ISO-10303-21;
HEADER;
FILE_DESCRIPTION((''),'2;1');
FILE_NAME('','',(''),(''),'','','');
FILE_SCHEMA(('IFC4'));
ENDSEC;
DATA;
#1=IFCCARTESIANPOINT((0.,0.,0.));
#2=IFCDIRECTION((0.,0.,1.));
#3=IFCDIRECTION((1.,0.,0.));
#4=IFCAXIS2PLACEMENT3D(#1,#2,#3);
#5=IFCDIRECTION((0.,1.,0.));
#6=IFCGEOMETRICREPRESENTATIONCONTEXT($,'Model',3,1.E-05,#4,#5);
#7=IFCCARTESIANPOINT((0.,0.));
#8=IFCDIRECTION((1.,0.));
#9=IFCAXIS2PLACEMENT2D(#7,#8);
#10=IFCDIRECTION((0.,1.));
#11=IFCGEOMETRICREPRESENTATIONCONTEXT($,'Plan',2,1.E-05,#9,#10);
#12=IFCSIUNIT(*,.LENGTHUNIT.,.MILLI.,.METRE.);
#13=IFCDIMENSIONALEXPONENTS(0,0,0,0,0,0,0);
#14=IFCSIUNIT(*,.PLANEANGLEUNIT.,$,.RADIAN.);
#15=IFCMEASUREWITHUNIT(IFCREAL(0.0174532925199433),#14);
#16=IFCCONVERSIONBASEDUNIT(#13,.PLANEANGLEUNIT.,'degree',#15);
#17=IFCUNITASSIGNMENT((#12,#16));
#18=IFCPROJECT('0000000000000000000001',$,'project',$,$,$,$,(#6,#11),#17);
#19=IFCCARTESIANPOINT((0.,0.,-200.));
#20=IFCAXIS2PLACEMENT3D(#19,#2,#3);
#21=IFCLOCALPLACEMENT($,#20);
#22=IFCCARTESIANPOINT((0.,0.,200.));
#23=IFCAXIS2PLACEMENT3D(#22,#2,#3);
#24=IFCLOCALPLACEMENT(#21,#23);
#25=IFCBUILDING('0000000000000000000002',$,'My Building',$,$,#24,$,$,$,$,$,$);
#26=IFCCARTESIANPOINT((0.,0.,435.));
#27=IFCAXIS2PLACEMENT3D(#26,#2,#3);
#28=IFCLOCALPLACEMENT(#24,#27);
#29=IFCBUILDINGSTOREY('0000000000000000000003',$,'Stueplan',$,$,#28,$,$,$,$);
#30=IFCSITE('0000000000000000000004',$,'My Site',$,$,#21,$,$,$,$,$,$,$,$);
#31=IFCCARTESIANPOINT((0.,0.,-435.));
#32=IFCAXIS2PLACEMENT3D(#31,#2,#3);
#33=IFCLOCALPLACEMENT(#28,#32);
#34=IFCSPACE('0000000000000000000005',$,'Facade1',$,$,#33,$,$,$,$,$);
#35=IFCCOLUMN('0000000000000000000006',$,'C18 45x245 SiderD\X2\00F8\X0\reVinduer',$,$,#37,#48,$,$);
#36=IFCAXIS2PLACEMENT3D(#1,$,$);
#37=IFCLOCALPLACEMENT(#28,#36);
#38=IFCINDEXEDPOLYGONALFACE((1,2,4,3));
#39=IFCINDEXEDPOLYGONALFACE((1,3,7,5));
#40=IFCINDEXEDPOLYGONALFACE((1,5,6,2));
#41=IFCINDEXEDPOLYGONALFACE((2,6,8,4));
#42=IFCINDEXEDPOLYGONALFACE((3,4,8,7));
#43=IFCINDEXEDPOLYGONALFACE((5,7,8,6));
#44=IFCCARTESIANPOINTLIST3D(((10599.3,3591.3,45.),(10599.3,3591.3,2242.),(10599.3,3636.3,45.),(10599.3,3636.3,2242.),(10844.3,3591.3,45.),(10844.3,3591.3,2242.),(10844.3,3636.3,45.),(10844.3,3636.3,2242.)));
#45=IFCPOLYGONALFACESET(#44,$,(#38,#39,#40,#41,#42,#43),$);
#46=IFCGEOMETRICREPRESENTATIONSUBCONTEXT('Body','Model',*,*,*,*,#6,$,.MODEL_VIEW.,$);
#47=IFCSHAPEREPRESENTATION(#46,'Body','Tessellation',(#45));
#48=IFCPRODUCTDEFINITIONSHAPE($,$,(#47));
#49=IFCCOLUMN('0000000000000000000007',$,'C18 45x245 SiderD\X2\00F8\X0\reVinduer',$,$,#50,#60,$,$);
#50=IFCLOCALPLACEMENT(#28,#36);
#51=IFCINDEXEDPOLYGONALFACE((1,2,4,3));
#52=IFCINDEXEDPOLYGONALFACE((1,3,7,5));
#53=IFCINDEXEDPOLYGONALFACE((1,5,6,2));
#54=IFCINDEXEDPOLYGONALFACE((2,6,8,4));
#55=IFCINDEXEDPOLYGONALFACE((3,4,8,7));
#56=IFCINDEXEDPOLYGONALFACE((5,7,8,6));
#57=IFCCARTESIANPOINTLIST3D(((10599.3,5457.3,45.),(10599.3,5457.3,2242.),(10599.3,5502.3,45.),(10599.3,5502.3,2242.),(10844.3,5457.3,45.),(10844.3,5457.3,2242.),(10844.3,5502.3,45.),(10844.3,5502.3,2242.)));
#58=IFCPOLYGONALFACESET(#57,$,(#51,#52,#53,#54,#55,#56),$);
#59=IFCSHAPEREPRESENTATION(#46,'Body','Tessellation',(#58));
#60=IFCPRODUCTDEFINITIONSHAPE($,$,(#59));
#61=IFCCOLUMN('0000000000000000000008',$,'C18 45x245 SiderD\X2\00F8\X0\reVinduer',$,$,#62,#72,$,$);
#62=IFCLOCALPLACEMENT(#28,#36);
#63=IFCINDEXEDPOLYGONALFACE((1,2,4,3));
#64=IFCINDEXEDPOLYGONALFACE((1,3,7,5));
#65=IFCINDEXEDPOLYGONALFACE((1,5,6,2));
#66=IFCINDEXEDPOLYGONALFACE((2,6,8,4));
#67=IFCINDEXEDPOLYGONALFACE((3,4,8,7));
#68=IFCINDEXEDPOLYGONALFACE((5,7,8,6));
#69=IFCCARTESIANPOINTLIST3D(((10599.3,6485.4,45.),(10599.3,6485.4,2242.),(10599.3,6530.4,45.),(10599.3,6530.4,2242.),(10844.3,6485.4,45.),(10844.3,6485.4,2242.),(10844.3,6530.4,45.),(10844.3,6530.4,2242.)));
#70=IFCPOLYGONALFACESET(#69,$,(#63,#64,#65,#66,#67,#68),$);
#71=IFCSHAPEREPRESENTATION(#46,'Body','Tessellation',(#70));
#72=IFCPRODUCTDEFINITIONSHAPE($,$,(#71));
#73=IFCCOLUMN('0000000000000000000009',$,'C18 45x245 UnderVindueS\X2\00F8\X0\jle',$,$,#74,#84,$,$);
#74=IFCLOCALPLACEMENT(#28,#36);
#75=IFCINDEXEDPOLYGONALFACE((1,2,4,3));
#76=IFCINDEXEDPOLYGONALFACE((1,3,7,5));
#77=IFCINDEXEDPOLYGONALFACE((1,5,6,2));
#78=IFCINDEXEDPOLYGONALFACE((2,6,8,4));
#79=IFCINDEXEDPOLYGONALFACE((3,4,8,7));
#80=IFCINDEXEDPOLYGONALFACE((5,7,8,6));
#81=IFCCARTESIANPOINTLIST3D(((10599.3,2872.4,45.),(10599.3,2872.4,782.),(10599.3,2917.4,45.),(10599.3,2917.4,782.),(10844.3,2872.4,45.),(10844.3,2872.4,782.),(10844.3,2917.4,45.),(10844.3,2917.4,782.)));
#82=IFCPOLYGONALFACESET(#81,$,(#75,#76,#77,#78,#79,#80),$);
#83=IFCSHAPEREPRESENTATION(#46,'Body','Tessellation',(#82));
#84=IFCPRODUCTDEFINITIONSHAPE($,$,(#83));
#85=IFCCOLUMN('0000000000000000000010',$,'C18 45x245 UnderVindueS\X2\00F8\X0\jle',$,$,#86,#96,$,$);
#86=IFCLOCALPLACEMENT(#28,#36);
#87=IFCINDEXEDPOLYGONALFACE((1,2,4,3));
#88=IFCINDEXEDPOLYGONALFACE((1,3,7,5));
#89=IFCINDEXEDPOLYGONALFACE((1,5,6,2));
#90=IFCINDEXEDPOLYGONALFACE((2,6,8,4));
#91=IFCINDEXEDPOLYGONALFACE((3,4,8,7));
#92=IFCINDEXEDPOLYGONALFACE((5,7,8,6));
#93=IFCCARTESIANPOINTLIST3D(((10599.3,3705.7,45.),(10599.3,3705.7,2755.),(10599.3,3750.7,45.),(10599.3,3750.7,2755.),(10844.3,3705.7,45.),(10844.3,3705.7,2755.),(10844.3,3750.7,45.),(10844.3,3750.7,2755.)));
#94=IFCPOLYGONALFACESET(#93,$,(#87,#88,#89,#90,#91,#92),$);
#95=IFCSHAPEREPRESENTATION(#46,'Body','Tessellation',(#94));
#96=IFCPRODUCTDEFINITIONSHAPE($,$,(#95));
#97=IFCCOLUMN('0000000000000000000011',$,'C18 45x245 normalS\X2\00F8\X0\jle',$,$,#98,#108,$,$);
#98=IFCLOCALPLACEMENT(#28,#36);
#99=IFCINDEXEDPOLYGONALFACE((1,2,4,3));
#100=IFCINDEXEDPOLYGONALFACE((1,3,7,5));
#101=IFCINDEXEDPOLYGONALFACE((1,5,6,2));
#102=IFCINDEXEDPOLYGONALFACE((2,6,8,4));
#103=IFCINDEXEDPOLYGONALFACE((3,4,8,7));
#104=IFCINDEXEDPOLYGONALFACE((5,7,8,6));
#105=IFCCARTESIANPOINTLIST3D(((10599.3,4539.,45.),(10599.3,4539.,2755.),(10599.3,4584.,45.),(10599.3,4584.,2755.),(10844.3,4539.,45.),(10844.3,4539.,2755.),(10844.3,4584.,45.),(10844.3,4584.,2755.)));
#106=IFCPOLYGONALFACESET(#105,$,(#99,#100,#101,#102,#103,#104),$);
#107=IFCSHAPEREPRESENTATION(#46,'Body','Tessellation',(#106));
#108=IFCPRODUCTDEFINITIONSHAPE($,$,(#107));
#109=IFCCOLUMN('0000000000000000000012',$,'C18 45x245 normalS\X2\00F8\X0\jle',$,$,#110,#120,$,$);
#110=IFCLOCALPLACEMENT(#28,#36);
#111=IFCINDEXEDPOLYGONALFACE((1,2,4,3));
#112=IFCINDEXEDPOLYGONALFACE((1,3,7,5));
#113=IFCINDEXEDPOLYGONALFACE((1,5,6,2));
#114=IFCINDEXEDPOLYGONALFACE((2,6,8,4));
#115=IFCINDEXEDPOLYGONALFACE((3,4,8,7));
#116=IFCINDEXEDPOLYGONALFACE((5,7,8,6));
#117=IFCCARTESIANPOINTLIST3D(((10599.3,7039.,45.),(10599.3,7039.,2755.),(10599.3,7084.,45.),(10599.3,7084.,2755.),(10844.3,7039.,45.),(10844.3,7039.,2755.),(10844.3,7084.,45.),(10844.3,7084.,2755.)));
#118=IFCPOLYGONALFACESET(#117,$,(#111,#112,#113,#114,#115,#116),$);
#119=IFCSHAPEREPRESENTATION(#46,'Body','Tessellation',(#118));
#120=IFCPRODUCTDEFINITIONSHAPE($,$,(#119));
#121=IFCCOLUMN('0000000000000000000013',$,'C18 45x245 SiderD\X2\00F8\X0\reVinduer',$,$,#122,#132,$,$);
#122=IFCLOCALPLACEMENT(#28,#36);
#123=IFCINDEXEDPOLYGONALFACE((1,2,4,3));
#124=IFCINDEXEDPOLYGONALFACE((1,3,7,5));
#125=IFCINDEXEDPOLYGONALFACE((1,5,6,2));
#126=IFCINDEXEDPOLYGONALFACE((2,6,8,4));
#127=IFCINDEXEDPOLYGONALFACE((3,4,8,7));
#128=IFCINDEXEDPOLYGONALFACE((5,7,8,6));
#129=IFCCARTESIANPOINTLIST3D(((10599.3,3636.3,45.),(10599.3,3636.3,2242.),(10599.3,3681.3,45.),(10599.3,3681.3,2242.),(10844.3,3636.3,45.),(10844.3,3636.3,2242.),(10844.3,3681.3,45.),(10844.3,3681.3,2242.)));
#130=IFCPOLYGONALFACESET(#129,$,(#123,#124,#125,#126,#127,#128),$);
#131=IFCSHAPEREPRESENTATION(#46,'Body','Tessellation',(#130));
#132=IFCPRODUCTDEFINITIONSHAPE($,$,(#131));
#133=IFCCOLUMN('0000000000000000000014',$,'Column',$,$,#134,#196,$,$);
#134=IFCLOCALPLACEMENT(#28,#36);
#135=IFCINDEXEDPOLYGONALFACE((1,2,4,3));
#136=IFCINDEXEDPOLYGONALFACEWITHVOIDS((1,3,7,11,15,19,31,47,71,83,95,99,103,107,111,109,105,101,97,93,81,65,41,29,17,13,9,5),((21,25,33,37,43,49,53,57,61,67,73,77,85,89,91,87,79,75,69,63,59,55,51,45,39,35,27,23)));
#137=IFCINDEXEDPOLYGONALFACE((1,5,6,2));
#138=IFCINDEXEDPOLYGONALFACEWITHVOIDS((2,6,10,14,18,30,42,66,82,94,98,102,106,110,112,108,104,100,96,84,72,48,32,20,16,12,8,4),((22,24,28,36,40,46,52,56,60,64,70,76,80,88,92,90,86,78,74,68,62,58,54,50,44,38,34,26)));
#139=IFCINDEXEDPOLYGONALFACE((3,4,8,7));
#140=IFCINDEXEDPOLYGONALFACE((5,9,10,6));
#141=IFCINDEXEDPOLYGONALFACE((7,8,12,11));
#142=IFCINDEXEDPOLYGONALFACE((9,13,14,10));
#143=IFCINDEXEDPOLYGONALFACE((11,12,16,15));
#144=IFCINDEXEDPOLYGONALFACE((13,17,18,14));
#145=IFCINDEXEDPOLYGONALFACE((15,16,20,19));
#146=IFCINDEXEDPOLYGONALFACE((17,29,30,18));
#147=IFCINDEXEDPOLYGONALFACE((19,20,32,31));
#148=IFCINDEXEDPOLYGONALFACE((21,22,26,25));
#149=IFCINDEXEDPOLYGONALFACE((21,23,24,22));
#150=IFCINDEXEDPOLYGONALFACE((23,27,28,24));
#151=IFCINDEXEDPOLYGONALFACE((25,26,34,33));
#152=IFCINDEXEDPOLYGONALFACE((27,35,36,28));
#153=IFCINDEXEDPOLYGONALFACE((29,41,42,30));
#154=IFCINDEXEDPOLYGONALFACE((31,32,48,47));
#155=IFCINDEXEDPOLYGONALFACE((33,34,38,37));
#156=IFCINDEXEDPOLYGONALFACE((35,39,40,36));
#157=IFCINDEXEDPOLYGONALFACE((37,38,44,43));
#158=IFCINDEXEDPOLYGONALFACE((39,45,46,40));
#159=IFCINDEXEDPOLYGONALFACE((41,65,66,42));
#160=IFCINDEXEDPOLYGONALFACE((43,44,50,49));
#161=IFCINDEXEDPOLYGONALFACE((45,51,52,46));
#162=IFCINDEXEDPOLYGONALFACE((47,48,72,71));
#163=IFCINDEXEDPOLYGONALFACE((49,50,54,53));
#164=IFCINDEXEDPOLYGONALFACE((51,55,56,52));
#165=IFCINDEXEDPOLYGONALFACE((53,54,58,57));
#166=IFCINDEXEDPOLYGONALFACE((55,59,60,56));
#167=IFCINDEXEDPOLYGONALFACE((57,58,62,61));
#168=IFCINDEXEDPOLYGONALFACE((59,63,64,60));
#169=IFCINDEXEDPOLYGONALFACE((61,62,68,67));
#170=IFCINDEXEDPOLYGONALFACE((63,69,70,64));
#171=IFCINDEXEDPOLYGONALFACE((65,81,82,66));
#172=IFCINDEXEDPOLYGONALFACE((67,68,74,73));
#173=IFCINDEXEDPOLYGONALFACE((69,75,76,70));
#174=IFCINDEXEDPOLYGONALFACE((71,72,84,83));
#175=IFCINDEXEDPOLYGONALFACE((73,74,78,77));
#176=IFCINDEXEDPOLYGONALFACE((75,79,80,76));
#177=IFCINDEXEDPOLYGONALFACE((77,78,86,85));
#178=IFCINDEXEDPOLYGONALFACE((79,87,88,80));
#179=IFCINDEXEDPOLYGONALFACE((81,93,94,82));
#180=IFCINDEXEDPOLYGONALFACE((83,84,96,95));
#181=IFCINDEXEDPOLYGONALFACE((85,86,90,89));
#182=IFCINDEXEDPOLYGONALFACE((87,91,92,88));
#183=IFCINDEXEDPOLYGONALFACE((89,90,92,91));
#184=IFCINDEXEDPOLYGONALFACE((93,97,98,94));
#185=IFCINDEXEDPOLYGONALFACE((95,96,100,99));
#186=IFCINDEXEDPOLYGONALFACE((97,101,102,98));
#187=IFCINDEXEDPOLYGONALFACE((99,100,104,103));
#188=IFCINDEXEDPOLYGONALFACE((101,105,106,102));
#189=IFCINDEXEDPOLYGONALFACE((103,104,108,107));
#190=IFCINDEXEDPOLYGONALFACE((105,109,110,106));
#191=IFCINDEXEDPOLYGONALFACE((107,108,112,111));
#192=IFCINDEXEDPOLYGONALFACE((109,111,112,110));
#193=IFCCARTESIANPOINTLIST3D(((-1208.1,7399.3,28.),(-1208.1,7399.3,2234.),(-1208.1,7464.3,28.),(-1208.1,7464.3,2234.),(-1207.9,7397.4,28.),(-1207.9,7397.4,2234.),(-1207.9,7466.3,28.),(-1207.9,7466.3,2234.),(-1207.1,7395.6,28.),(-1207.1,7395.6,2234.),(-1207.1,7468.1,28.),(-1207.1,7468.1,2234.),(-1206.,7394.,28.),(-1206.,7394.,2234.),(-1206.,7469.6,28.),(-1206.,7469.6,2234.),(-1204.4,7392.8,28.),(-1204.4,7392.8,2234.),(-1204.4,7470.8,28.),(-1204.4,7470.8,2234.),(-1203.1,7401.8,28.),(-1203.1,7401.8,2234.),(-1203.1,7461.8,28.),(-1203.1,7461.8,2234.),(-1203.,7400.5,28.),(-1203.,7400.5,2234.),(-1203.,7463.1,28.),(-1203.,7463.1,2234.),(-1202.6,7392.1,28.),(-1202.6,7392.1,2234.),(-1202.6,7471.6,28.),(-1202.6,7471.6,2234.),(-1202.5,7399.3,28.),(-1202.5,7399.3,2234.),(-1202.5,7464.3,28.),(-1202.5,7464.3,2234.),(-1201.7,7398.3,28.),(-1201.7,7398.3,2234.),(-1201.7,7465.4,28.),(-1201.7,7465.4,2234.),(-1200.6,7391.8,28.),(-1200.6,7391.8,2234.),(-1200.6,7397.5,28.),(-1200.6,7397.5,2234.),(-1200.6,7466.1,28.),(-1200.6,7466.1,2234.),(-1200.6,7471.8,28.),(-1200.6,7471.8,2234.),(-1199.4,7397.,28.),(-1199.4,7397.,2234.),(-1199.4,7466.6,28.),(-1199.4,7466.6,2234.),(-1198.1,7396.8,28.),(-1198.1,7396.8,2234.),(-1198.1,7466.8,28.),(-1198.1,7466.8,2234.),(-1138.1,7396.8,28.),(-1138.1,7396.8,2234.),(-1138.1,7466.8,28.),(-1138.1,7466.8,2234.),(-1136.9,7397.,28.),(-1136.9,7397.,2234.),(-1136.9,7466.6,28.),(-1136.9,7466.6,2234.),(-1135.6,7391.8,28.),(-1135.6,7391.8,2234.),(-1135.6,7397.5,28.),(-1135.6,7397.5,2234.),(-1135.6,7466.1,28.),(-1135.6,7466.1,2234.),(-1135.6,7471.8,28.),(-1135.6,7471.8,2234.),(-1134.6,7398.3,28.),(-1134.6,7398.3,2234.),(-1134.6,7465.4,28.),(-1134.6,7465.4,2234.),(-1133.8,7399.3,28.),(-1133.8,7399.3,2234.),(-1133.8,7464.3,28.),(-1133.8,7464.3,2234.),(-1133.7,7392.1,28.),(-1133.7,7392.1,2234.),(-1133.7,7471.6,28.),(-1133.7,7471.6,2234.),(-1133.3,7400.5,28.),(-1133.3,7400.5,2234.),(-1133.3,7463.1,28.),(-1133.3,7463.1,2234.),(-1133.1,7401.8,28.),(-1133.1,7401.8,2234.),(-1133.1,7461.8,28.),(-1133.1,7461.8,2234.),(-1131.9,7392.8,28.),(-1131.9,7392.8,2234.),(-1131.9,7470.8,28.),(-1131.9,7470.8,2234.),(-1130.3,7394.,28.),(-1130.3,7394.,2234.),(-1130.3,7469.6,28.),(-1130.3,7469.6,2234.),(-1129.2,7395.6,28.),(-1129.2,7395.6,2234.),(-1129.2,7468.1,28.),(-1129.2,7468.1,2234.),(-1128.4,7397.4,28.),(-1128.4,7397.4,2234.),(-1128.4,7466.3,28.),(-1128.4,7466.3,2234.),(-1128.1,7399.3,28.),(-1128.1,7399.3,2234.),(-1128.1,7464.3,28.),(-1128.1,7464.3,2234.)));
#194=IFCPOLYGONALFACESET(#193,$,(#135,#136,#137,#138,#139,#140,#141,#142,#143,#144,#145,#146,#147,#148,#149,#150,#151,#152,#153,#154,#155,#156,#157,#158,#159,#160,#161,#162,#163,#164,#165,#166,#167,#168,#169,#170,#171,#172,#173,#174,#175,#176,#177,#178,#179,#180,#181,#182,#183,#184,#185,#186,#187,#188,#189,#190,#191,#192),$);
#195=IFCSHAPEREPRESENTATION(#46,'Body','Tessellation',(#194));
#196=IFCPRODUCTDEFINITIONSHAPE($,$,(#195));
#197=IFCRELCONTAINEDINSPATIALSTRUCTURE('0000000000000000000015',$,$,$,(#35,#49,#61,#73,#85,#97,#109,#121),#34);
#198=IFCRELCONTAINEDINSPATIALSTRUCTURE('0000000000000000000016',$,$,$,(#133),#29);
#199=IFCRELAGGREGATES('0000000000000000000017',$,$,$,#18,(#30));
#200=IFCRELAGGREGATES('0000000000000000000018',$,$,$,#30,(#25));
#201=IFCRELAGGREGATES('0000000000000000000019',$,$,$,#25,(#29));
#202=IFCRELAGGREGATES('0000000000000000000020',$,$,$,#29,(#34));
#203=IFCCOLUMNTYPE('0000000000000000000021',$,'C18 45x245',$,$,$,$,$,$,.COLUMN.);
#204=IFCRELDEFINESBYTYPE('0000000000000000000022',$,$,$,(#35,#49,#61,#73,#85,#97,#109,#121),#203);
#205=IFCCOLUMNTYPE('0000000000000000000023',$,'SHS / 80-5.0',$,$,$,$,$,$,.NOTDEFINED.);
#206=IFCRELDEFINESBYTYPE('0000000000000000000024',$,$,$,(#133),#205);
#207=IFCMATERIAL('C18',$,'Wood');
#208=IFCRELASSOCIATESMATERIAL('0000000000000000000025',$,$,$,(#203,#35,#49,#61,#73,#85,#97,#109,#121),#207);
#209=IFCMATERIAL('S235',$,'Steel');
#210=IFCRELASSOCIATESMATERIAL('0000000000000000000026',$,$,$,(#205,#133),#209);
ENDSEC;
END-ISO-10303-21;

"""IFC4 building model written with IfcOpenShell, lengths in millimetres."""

from ifc_helpers import new_model, entity, si_unit, converted_unit, direction, frame, origin_with_axes, origin_2d_with_axis, place, context, subcontext, project, spatial, rectangle, hollow_rectangle, extrude, material, material_profile, profile_set, profile_usage, type_object, element, save


model = new_model("IFC4")

# Units and contexts
model_context = context("Model", 3, precision=1e-05, world=origin_with_axes(), true_north=direction((0.0, 1.0, 0.0)))
plan_context = context("Plan", 2, precision=1e-05, world=origin_2d_with_axis(), true_north=direction((0.0, 1.0)))
body_context_1 = subcontext(model_context, "Body", "Model", "MODEL_VIEW")
ifc_project = project(units=[si_unit("LENGTHUNIT", "METRE", prefix="MILLI"), converted_unit("PLANEANGLEUNIT", "degree", entity("IfcReal", 0.0174532925199433), si_unit("PLANEANGLEUNIT", "RADIAN"), dimensions=[0, 0, 0, 0, 0, 0, 0])], contexts=[model_context, plan_context])

# Site, building, storey, space
site_placement = place(None, frame((0.0, 0.0, -200.0), z_axis=(0.0, 0.0, 1.0), x_axis=(1.0, 0.0, 0.0)))
site = spatial("IfcSite", under=ifc_project, at=site_placement, Name="My Site")
building_placement = place(site_placement, frame((0.0, 0.0, 200.0), z_axis=(0.0, 0.0, 1.0), x_axis=(1.0, 0.0, 0.0)))
building = spatial("IfcBuilding", under=site, at=building_placement, Name="My Building")
storey_placement = place(building_placement, frame((0.0, 0.0, 435.0), z_axis=(0.0, 0.0, 1.0), x_axis=(1.0, 0.0, 0.0)))
storey = spatial("IfcBuildingStorey", under=building, at=storey_placement, Name="Stueplan")
space_1_placement = place(storey_placement, frame((0.0, 0.0, -435.0), z_axis=(0.0, 0.0, 1.0), x_axis=(1.0, 0.0, 0.0)))
space_1 = spatial("IfcSpace", under=storey, at=space_1_placement, Name="Facade1")

# Columns
ifc_material_1 = material(Name="C18", Category="Wood")
ifc_material_profile_1 = material_profile(ifc_material_1, rectangle(XDim=45.0, YDim=245.0))
ifc_profile_set_1 = profile_set([ifc_material_profile_1], Name="woodStructural")
ifc_profile_usage_1 = profile_usage(ifc_profile_set_1, cardinal=9)
column_type_1 = type_object("IfcColumnType", Name="C18 45x245", PredefinedType="COLUMN", material=ifc_profile_set_1)
column_1_placement = place(space_1_placement, frame((10844.3, 3636.3, 480.0), z_axis=(0.0, 0.0, 1.0), x_axis=(0.0, -1.0, 0.0)))
element("IfcColumn", 1, at=column_1_placement, inside=space_1, type_object=column_type_1, material=ifc_profile_usage_1, Name="C18 45x245 SiderDøreVinduer", context=body_context_1, shape_type="SweptSolid", body=[
    extrude(rectangle(XDim=45.0, YDim=245.0), frame((22.5, -122.5, 0.0), z_axis=(0.0, 0.0, 1.0), x_axis=(1.0, 0.0, 0.0)), (0.0, 0.0, 1.0), 2197.0),
])
ifc_profile_usage_2 = profile_usage(ifc_profile_set_1, cardinal=9)
column_2_placement = place(space_1_placement, frame((10844.3, 5502.3, 480.0), z_axis=(0.0, 0.0, 1.0), x_axis=(0.0, -1.0, 0.0)))
element("IfcColumn", 2, at=column_2_placement, inside=space_1, type_object=column_type_1, material=ifc_profile_usage_2, Name="C18 45x245 SiderDøreVinduer", context=body_context_1, shape_type="SweptSolid", body=[
    extrude(rectangle(XDim=45.0, YDim=245.0), frame((22.5, -122.5, 0.0), z_axis=(0.0, 0.0, 1.0), x_axis=(1.0, 0.0, 0.0)), (0.0, 0.0, 1.0), 2197.0),
])
ifc_profile_usage_3 = profile_usage(ifc_profile_set_1, cardinal=9)
column_3_placement = place(space_1_placement, frame((10844.3, 6530.4, 480.0), z_axis=(0.0, 0.0, 1.0), x_axis=(0.0, -1.0, 0.0)))
element("IfcColumn", 3, at=column_3_placement, inside=space_1, type_object=column_type_1, material=ifc_profile_usage_3, Name="C18 45x245 SiderDøreVinduer", context=body_context_1, shape_type="SweptSolid", body=[
    extrude(rectangle(XDim=45.0, YDim=245.0), frame((22.5, -122.5, 0.0), z_axis=(0.0, 0.0, 1.0), x_axis=(1.0, 0.0, 0.0)), (0.0, 0.0, 1.0), 2197.0),
])
ifc_profile_usage_4 = profile_usage(ifc_profile_set_1, cardinal=9)
column_4_placement = place(space_1_placement, frame((10844.3, 2917.4, 480.0), z_axis=(0.0, 0.0, 1.0), x_axis=(0.0, -1.0, 0.0)))
element("IfcColumn", 4, at=column_4_placement, inside=space_1, type_object=column_type_1, material=ifc_profile_usage_4, Name="C18 45x245 UnderVindueSøjle", context=body_context_1, shape_type="SweptSolid", body=[
    extrude(rectangle(XDim=45.0, YDim=245.0), frame((22.5, -122.5, 0.0), z_axis=(0.0, 0.0, 1.0), x_axis=(1.0, 0.0, 0.0)), (0.0, 0.0, 1.0), 737.0),
])
ifc_profile_usage_5 = profile_usage(ifc_profile_set_1, cardinal=9)
column_5_placement = place(space_1_placement, frame((10844.3, 3750.7, 480.0), z_axis=(0.0, 0.0, 1.0), x_axis=(0.0, -1.0, 0.0)))
element("IfcColumn", 5, at=column_5_placement, inside=space_1, type_object=column_type_1, material=ifc_profile_usage_5, Name="C18 45x245 UnderVindueSøjle", context=body_context_1, shape_type="SweptSolid", body=[
    extrude(rectangle(XDim=45.0, YDim=245.0), frame((22.5, -122.5, 0.0), z_axis=(0.0, 0.0, 1.0), x_axis=(1.0, 0.0, 0.0)), (0.0, 0.0, 1.0), 2710.0),
])
ifc_profile_usage_6 = profile_usage(ifc_profile_set_1, cardinal=9)
column_6_placement = place(space_1_placement, frame((10844.3, 4584.0, 480.0), z_axis=(0.0, 0.0, 1.0), x_axis=(0.0, -1.0, 0.0)))
element("IfcColumn", 6, at=column_6_placement, inside=space_1, type_object=column_type_1, material=ifc_profile_usage_6, Name="C18 45x245 normalSøjle", context=body_context_1, shape_type="SweptSolid", body=[
    extrude(rectangle(XDim=45.0, YDim=245.0), frame((22.5, -122.5, 0.0), z_axis=(0.0, 0.0, 1.0), x_axis=(1.0, 0.0, 0.0)), (0.0, 0.0, 1.0), 2710.0),
])
ifc_profile_usage_7 = profile_usage(ifc_profile_set_1, cardinal=9)
column_7_placement = place(space_1_placement, frame((10844.3, 7084.0, 480.0), z_axis=(0.0, 0.0, 1.0), x_axis=(0.0, -1.0, 0.0)))
element("IfcColumn", 7, at=column_7_placement, inside=space_1, type_object=column_type_1, material=ifc_profile_usage_7, Name="C18 45x245 normalSøjle", context=body_context_1, shape_type="SweptSolid", body=[
    extrude(rectangle(XDim=45.0, YDim=245.0), frame((22.5, -122.5, 0.0), z_axis=(0.0, 0.0, 1.0), x_axis=(1.0, 0.0, 0.0)), (0.0, 0.0, 1.0), 2710.0),
])
ifc_profile_usage_8 = profile_usage(ifc_profile_set_1, cardinal=9)
column_8_placement = place(space_1_placement, frame((10844.3, 3681.3, 480.0), z_axis=(0.0, 0.0, 1.0), x_axis=(0.0, -1.0, 0.0)))
element("IfcColumn", 8, at=column_8_placement, inside=space_1, type_object=column_type_1, material=ifc_profile_usage_8, Name="C18 45x245 SiderDøreVinduer", context=body_context_1, shape_type="SweptSolid", body=[
    extrude(rectangle(XDim=45.0, YDim=245.0), frame((22.5, -122.5, 0.0), z_axis=(0.0, 0.0, 1.0), x_axis=(1.0, 0.0, 0.0)), (0.0, 0.0, 1.0), 2197.0),
])
ifc_material_2 = material(Name="S235", Category="Steel")
ifc_material_profile_2 = material_profile(ifc_material_2, hollow_rectangle(XDim=80.0, YDim=80.0, WallThickness=5.0, InnerFilletRadius=5.0, OuterFilletRadius=7.5))
ifc_profile_set_2 = profile_set([ifc_material_profile_2], Name="steel")
ifc_profile_usage_9 = profile_usage(ifc_profile_set_2, cardinal=5)
column_type_2 = type_object("IfcColumnType", Name="SHS / 80-5.0", PredefinedType="NOTDEFINED", material=ifc_profile_set_2)
column_9_placement = place(storey_placement, frame((-1168.1, 7431.8, 28.0), z_axis=(0.0, 0.0, 1.0), x_axis=(1.0, 0.0, 0.0)))
element("IfcColumn", 9, at=column_9_placement, inside=storey, type_object=column_type_2, material=ifc_profile_usage_9, Name="Column", context=body_context_1, shape_type="SweptSolid", body=[
    extrude(hollow_rectangle(XDim=80.0, YDim=80.0, WallThickness=5.0, InnerFilletRadius=5.0, OuterFilletRadius=7.5), origin_with_axes(), (0.0, 0.0, 1.0), 2206.0),
])

save(model, "model.ifc")
